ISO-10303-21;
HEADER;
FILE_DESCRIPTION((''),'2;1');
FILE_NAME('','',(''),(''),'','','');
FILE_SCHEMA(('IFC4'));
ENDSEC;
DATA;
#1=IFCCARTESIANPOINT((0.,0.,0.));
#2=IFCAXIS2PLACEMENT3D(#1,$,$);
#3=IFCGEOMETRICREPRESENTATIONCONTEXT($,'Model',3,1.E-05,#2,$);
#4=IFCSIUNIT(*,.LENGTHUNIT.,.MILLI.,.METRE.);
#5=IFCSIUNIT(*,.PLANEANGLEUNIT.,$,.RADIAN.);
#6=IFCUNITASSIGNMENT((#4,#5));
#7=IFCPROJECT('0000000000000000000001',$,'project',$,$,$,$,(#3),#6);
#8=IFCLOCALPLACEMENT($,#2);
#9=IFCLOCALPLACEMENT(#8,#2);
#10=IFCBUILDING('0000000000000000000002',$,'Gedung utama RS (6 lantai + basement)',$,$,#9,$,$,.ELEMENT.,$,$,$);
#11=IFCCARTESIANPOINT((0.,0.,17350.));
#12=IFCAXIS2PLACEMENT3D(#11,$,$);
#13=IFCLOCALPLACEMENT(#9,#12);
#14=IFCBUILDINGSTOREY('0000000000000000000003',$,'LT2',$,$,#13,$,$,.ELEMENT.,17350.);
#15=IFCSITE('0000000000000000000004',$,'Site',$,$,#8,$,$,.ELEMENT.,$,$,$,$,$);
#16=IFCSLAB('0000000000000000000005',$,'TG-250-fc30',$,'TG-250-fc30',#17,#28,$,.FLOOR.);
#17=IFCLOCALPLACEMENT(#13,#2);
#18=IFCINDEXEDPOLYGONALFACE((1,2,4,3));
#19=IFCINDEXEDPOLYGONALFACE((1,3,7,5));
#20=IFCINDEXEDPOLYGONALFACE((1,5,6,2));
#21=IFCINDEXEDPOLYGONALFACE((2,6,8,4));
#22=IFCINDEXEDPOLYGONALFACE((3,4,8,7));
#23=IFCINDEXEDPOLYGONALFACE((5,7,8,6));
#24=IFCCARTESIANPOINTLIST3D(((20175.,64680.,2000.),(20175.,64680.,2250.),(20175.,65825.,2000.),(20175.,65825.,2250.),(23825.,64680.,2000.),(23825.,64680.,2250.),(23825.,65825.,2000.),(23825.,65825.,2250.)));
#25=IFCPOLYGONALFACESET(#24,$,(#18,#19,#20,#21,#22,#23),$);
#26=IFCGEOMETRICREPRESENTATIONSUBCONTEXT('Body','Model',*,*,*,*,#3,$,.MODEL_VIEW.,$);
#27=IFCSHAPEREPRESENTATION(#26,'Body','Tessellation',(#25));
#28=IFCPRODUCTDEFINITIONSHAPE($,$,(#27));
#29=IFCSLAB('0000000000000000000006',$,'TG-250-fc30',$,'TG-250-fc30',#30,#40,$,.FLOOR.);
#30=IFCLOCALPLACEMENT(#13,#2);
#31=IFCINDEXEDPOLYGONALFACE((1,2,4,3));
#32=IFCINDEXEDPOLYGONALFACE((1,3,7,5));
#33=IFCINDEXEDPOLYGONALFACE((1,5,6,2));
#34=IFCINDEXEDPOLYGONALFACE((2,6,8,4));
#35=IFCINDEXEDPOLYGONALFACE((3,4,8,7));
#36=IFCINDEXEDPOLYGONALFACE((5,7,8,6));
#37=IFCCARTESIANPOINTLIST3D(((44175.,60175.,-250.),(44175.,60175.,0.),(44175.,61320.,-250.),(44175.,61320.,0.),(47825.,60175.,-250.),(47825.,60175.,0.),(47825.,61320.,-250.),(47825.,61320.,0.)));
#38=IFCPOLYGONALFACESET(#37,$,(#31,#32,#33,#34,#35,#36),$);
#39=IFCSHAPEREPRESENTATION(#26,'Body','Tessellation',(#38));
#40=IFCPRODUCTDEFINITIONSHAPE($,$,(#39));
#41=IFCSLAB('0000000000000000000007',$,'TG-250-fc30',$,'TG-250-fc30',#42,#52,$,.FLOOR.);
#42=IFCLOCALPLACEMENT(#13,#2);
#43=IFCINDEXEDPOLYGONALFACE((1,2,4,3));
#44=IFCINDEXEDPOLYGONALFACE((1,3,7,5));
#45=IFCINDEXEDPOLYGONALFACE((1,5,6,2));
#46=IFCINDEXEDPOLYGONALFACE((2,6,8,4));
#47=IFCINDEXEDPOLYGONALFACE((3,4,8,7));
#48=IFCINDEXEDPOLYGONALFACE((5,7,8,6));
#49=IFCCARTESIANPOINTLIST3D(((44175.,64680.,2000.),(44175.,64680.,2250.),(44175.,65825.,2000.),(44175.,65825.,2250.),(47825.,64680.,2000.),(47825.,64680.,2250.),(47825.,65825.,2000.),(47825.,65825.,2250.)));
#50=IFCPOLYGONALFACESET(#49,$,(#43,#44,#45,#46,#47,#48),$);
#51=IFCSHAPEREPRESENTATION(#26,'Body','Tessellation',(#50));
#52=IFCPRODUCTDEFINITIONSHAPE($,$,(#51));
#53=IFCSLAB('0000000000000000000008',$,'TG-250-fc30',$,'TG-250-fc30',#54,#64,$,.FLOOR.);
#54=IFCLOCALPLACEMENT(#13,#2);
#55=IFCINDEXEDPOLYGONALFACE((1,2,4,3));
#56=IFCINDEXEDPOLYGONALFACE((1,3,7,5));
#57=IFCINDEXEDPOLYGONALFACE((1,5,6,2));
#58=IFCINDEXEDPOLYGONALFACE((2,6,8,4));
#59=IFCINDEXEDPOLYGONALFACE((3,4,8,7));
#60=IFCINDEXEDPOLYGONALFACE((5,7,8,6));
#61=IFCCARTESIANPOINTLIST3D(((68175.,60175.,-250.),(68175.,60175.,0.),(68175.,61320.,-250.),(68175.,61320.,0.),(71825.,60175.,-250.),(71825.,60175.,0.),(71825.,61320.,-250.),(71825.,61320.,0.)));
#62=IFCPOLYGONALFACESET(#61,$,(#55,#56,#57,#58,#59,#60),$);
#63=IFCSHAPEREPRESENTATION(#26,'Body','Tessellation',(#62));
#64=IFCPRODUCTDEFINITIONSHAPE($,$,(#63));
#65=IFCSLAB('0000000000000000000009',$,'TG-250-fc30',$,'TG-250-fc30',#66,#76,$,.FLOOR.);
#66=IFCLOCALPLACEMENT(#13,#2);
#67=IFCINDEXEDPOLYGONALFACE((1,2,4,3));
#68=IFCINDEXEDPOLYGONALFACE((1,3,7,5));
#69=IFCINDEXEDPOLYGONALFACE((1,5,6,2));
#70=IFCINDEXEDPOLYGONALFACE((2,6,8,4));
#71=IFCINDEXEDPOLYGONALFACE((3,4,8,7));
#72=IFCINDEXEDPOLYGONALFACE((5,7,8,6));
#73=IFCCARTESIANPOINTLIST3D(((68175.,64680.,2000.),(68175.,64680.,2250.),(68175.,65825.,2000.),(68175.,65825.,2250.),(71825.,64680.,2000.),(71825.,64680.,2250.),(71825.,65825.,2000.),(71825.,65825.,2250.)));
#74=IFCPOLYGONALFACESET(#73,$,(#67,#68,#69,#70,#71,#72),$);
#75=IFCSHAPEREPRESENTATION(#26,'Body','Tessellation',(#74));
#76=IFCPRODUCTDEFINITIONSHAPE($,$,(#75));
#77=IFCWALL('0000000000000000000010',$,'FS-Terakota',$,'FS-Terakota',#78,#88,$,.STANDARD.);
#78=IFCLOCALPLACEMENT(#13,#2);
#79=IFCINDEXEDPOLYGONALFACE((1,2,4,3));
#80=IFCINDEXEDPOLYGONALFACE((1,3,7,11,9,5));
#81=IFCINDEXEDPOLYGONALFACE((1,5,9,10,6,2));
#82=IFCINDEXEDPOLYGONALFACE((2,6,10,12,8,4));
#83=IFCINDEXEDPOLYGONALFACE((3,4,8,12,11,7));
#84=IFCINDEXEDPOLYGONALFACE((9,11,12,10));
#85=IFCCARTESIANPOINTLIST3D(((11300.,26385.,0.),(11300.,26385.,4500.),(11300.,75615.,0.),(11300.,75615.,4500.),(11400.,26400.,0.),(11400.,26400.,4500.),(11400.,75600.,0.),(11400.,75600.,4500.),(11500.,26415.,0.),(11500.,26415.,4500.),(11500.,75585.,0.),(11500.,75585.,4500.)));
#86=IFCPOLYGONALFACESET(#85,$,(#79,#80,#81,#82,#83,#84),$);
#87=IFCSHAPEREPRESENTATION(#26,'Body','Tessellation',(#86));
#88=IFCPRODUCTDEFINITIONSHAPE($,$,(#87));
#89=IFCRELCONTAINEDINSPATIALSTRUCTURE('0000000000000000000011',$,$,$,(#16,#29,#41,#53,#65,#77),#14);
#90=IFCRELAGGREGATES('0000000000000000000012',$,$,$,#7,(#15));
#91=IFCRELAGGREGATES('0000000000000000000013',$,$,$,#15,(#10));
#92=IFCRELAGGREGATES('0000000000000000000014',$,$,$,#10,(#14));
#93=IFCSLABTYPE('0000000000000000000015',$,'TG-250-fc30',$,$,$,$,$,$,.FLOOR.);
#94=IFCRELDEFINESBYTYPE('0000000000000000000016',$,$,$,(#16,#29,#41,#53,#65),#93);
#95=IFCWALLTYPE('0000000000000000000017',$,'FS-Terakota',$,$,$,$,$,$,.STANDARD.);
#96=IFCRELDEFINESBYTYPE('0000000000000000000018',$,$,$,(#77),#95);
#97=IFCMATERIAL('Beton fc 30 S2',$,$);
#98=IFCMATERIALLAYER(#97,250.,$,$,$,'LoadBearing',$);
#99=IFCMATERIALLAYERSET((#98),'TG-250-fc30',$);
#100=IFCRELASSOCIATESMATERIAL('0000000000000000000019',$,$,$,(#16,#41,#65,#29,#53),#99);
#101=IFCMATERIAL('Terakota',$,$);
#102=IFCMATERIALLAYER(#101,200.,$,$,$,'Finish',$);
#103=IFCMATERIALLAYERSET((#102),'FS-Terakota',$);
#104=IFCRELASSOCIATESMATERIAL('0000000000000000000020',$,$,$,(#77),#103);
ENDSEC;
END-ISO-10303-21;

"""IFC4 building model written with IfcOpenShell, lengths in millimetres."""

from ifc_helpers import new_model, si_unit, frame, origin, place, context, subcontext, project, spatial, polyline, outline, extrude, material, layer, layer_set, layer_usage, type_object, element, save


model = new_model("IFC4")

# Units and contexts
model_context = context("Model", 3, precision=1e-05, world=origin())
body_context = subcontext(model_context, "Body", "Model", "MODEL_VIEW")
ifc_project = project(units=[si_unit("LENGTHUNIT", "METRE", prefix="MILLI"), si_unit("PLANEANGLEUNIT", "RADIAN")], contexts=[model_context])

# Site, building, storey
site_placement = place(None, origin())
site = spatial("IfcSite", under=ifc_project, at=site_placement, Name="Site", CompositionType="ELEMENT")
building_placement = place(site_placement, origin())
building = spatial("IfcBuilding", under=site, at=building_placement, Name="Gedung utama RS (6 lantai + basement)", CompositionType="ELEMENT")
storey_placement = place(building_placement, frame((0.0, 0.0, 17350.0)))
storey = spatial("IfcBuildingStorey", under=building, at=storey_placement, Name="LT2", CompositionType="ELEMENT", Elevation=17350.0)

# Shared definitions
ifc_material_1 = material(Name="Beton fc 30 S2")

# Slabs
ifc_layer_1 = layer(ifc_material_1, 250.0, Category="LoadBearing")
ifc_layer_set_1 = layer_set([ifc_layer_1], Name="TG-250-fc30")
ifc_layer_usage_1 = layer_usage(ifc_layer_set_1, "AXIS3", "NEGATIVE", 0.0)
slab_type_1 = type_object("IfcSlabType", Name="TG-250-fc30", PredefinedType="FLOOR")
ifc_layer_usage_2 = layer_usage(ifc_layer_set_1, "AXIS3", "NEGATIVE", 2250.0)
slab_1_placement = place(storey_placement, origin())
element("IfcSlab", 1, at=slab_1_placement, inside=storey, type_object=slab_type_1, material=ifc_layer_usage_2, Name="TG-250-fc30", ObjectType="TG-250-fc30", PredefinedType="FLOOR", context=body_context, shape_type="SweptSolid", body=[
    extrude(outline(polyline([(23825.0, 64680.0), (23825.0, 65825.0), (20175.0, 65825.0), (20175.0, 64680.0), (23825.0, 64680.0)])), frame((0.0, 0.0, 2000.0)), (0.0, 0.0, 1.0), 250.0),
])
slab_2_placement = place(storey_placement, origin())
element("IfcSlab", 2, at=slab_2_placement, inside=storey, type_object=slab_type_1, material=ifc_layer_usage_1, Name="TG-250-fc30", ObjectType="TG-250-fc30", PredefinedType="FLOOR", context=body_context, shape_type="SweptSolid", body=[
    extrude(outline(polyline([(47825.0, 60175.0), (47825.0, 61320.0), (44175.0, 61320.0), (44175.0, 60175.0), (47825.0, 60175.0)])), frame((0.0, 0.0, -250.0)), (0.0, 0.0, 1.0), 250.0),
])
slab_3_placement = place(storey_placement, origin())
element("IfcSlab", 3, at=slab_3_placement, inside=storey, type_object=slab_type_1, material=ifc_layer_usage_2, Name="TG-250-fc30", ObjectType="TG-250-fc30", PredefinedType="FLOOR", context=body_context, shape_type="SweptSolid", body=[
    extrude(outline(polyline([(47825.0, 64680.0), (47825.0, 65825.0), (44175.0, 65825.0), (44175.0, 64680.0), (47825.0, 64680.0)])), frame((0.0, 0.0, 2000.0)), (0.0, 0.0, 1.0), 250.0),
])
slab_4_placement = place(storey_placement, origin())
element("IfcSlab", 4, at=slab_4_placement, inside=storey, type_object=slab_type_1, material=ifc_layer_usage_1, Name="TG-250-fc30", ObjectType="TG-250-fc30", PredefinedType="FLOOR", context=body_context, shape_type="SweptSolid", body=[
    extrude(outline(polyline([(71825.0, 60175.0), (71825.0, 61320.0), (68175.0, 61320.0), (68175.0, 60175.0), (71825.0, 60175.0)])), frame((0.0, 0.0, -250.0)), (0.0, 0.0, 1.0), 250.0),
])
slab_5_placement = place(storey_placement, origin())
element("IfcSlab", 5, at=slab_5_placement, inside=storey, type_object=slab_type_1, material=ifc_layer_usage_2, Name="TG-250-fc30", ObjectType="TG-250-fc30", PredefinedType="FLOOR", context=body_context, shape_type="SweptSolid", body=[
    extrude(outline(polyline([(71825.0, 64680.0), (71825.0, 65825.0), (68175.0, 65825.0), (68175.0, 64680.0), (71825.0, 64680.0)])), frame((0.0, 0.0, 2000.0)), (0.0, 0.0, 1.0), 250.0),
])

# Wall
ifc_material_2 = material(Name="Terakota")
ifc_layer_2 = layer(ifc_material_2, 200.0, Category="Finish")
ifc_layer_set_2 = layer_set([ifc_layer_2], Name="FS-Terakota")
ifc_layer_usage_3 = layer_usage(ifc_layer_set_2, "AXIS2", "NEGATIVE", 100.0)
wall_type = type_object("IfcWallType", Name="FS-Terakota", PredefinedType="STANDARD")
wall_placement = place(storey_placement, frame((11400.0, 26400.0, 0.0), z_axis=(0.0, 0.0, 1.0), x_axis=(0.0, 1.0, 0.0)))
element("IfcWall", 6, at=wall_placement, inside=storey, type_object=wall_type, material=ifc_layer_usage_3, Name="FS-Terakota", ObjectType="FS-Terakota", PredefinedType="STANDARD", context=body_context, shape_type="SweptSolid", body=[
    extrude(outline(polyline([(15.0, -100.0), (0.0, 0.0), (-15.0, 100.0), (49215.0, 100.0), (49200.0, 0.0), (49185.0, -100.0), (15.0, -100.0)])), origin(), (0.0, 0.0, 1.0), 4500.0),
])

save(model, "model.ifc")
